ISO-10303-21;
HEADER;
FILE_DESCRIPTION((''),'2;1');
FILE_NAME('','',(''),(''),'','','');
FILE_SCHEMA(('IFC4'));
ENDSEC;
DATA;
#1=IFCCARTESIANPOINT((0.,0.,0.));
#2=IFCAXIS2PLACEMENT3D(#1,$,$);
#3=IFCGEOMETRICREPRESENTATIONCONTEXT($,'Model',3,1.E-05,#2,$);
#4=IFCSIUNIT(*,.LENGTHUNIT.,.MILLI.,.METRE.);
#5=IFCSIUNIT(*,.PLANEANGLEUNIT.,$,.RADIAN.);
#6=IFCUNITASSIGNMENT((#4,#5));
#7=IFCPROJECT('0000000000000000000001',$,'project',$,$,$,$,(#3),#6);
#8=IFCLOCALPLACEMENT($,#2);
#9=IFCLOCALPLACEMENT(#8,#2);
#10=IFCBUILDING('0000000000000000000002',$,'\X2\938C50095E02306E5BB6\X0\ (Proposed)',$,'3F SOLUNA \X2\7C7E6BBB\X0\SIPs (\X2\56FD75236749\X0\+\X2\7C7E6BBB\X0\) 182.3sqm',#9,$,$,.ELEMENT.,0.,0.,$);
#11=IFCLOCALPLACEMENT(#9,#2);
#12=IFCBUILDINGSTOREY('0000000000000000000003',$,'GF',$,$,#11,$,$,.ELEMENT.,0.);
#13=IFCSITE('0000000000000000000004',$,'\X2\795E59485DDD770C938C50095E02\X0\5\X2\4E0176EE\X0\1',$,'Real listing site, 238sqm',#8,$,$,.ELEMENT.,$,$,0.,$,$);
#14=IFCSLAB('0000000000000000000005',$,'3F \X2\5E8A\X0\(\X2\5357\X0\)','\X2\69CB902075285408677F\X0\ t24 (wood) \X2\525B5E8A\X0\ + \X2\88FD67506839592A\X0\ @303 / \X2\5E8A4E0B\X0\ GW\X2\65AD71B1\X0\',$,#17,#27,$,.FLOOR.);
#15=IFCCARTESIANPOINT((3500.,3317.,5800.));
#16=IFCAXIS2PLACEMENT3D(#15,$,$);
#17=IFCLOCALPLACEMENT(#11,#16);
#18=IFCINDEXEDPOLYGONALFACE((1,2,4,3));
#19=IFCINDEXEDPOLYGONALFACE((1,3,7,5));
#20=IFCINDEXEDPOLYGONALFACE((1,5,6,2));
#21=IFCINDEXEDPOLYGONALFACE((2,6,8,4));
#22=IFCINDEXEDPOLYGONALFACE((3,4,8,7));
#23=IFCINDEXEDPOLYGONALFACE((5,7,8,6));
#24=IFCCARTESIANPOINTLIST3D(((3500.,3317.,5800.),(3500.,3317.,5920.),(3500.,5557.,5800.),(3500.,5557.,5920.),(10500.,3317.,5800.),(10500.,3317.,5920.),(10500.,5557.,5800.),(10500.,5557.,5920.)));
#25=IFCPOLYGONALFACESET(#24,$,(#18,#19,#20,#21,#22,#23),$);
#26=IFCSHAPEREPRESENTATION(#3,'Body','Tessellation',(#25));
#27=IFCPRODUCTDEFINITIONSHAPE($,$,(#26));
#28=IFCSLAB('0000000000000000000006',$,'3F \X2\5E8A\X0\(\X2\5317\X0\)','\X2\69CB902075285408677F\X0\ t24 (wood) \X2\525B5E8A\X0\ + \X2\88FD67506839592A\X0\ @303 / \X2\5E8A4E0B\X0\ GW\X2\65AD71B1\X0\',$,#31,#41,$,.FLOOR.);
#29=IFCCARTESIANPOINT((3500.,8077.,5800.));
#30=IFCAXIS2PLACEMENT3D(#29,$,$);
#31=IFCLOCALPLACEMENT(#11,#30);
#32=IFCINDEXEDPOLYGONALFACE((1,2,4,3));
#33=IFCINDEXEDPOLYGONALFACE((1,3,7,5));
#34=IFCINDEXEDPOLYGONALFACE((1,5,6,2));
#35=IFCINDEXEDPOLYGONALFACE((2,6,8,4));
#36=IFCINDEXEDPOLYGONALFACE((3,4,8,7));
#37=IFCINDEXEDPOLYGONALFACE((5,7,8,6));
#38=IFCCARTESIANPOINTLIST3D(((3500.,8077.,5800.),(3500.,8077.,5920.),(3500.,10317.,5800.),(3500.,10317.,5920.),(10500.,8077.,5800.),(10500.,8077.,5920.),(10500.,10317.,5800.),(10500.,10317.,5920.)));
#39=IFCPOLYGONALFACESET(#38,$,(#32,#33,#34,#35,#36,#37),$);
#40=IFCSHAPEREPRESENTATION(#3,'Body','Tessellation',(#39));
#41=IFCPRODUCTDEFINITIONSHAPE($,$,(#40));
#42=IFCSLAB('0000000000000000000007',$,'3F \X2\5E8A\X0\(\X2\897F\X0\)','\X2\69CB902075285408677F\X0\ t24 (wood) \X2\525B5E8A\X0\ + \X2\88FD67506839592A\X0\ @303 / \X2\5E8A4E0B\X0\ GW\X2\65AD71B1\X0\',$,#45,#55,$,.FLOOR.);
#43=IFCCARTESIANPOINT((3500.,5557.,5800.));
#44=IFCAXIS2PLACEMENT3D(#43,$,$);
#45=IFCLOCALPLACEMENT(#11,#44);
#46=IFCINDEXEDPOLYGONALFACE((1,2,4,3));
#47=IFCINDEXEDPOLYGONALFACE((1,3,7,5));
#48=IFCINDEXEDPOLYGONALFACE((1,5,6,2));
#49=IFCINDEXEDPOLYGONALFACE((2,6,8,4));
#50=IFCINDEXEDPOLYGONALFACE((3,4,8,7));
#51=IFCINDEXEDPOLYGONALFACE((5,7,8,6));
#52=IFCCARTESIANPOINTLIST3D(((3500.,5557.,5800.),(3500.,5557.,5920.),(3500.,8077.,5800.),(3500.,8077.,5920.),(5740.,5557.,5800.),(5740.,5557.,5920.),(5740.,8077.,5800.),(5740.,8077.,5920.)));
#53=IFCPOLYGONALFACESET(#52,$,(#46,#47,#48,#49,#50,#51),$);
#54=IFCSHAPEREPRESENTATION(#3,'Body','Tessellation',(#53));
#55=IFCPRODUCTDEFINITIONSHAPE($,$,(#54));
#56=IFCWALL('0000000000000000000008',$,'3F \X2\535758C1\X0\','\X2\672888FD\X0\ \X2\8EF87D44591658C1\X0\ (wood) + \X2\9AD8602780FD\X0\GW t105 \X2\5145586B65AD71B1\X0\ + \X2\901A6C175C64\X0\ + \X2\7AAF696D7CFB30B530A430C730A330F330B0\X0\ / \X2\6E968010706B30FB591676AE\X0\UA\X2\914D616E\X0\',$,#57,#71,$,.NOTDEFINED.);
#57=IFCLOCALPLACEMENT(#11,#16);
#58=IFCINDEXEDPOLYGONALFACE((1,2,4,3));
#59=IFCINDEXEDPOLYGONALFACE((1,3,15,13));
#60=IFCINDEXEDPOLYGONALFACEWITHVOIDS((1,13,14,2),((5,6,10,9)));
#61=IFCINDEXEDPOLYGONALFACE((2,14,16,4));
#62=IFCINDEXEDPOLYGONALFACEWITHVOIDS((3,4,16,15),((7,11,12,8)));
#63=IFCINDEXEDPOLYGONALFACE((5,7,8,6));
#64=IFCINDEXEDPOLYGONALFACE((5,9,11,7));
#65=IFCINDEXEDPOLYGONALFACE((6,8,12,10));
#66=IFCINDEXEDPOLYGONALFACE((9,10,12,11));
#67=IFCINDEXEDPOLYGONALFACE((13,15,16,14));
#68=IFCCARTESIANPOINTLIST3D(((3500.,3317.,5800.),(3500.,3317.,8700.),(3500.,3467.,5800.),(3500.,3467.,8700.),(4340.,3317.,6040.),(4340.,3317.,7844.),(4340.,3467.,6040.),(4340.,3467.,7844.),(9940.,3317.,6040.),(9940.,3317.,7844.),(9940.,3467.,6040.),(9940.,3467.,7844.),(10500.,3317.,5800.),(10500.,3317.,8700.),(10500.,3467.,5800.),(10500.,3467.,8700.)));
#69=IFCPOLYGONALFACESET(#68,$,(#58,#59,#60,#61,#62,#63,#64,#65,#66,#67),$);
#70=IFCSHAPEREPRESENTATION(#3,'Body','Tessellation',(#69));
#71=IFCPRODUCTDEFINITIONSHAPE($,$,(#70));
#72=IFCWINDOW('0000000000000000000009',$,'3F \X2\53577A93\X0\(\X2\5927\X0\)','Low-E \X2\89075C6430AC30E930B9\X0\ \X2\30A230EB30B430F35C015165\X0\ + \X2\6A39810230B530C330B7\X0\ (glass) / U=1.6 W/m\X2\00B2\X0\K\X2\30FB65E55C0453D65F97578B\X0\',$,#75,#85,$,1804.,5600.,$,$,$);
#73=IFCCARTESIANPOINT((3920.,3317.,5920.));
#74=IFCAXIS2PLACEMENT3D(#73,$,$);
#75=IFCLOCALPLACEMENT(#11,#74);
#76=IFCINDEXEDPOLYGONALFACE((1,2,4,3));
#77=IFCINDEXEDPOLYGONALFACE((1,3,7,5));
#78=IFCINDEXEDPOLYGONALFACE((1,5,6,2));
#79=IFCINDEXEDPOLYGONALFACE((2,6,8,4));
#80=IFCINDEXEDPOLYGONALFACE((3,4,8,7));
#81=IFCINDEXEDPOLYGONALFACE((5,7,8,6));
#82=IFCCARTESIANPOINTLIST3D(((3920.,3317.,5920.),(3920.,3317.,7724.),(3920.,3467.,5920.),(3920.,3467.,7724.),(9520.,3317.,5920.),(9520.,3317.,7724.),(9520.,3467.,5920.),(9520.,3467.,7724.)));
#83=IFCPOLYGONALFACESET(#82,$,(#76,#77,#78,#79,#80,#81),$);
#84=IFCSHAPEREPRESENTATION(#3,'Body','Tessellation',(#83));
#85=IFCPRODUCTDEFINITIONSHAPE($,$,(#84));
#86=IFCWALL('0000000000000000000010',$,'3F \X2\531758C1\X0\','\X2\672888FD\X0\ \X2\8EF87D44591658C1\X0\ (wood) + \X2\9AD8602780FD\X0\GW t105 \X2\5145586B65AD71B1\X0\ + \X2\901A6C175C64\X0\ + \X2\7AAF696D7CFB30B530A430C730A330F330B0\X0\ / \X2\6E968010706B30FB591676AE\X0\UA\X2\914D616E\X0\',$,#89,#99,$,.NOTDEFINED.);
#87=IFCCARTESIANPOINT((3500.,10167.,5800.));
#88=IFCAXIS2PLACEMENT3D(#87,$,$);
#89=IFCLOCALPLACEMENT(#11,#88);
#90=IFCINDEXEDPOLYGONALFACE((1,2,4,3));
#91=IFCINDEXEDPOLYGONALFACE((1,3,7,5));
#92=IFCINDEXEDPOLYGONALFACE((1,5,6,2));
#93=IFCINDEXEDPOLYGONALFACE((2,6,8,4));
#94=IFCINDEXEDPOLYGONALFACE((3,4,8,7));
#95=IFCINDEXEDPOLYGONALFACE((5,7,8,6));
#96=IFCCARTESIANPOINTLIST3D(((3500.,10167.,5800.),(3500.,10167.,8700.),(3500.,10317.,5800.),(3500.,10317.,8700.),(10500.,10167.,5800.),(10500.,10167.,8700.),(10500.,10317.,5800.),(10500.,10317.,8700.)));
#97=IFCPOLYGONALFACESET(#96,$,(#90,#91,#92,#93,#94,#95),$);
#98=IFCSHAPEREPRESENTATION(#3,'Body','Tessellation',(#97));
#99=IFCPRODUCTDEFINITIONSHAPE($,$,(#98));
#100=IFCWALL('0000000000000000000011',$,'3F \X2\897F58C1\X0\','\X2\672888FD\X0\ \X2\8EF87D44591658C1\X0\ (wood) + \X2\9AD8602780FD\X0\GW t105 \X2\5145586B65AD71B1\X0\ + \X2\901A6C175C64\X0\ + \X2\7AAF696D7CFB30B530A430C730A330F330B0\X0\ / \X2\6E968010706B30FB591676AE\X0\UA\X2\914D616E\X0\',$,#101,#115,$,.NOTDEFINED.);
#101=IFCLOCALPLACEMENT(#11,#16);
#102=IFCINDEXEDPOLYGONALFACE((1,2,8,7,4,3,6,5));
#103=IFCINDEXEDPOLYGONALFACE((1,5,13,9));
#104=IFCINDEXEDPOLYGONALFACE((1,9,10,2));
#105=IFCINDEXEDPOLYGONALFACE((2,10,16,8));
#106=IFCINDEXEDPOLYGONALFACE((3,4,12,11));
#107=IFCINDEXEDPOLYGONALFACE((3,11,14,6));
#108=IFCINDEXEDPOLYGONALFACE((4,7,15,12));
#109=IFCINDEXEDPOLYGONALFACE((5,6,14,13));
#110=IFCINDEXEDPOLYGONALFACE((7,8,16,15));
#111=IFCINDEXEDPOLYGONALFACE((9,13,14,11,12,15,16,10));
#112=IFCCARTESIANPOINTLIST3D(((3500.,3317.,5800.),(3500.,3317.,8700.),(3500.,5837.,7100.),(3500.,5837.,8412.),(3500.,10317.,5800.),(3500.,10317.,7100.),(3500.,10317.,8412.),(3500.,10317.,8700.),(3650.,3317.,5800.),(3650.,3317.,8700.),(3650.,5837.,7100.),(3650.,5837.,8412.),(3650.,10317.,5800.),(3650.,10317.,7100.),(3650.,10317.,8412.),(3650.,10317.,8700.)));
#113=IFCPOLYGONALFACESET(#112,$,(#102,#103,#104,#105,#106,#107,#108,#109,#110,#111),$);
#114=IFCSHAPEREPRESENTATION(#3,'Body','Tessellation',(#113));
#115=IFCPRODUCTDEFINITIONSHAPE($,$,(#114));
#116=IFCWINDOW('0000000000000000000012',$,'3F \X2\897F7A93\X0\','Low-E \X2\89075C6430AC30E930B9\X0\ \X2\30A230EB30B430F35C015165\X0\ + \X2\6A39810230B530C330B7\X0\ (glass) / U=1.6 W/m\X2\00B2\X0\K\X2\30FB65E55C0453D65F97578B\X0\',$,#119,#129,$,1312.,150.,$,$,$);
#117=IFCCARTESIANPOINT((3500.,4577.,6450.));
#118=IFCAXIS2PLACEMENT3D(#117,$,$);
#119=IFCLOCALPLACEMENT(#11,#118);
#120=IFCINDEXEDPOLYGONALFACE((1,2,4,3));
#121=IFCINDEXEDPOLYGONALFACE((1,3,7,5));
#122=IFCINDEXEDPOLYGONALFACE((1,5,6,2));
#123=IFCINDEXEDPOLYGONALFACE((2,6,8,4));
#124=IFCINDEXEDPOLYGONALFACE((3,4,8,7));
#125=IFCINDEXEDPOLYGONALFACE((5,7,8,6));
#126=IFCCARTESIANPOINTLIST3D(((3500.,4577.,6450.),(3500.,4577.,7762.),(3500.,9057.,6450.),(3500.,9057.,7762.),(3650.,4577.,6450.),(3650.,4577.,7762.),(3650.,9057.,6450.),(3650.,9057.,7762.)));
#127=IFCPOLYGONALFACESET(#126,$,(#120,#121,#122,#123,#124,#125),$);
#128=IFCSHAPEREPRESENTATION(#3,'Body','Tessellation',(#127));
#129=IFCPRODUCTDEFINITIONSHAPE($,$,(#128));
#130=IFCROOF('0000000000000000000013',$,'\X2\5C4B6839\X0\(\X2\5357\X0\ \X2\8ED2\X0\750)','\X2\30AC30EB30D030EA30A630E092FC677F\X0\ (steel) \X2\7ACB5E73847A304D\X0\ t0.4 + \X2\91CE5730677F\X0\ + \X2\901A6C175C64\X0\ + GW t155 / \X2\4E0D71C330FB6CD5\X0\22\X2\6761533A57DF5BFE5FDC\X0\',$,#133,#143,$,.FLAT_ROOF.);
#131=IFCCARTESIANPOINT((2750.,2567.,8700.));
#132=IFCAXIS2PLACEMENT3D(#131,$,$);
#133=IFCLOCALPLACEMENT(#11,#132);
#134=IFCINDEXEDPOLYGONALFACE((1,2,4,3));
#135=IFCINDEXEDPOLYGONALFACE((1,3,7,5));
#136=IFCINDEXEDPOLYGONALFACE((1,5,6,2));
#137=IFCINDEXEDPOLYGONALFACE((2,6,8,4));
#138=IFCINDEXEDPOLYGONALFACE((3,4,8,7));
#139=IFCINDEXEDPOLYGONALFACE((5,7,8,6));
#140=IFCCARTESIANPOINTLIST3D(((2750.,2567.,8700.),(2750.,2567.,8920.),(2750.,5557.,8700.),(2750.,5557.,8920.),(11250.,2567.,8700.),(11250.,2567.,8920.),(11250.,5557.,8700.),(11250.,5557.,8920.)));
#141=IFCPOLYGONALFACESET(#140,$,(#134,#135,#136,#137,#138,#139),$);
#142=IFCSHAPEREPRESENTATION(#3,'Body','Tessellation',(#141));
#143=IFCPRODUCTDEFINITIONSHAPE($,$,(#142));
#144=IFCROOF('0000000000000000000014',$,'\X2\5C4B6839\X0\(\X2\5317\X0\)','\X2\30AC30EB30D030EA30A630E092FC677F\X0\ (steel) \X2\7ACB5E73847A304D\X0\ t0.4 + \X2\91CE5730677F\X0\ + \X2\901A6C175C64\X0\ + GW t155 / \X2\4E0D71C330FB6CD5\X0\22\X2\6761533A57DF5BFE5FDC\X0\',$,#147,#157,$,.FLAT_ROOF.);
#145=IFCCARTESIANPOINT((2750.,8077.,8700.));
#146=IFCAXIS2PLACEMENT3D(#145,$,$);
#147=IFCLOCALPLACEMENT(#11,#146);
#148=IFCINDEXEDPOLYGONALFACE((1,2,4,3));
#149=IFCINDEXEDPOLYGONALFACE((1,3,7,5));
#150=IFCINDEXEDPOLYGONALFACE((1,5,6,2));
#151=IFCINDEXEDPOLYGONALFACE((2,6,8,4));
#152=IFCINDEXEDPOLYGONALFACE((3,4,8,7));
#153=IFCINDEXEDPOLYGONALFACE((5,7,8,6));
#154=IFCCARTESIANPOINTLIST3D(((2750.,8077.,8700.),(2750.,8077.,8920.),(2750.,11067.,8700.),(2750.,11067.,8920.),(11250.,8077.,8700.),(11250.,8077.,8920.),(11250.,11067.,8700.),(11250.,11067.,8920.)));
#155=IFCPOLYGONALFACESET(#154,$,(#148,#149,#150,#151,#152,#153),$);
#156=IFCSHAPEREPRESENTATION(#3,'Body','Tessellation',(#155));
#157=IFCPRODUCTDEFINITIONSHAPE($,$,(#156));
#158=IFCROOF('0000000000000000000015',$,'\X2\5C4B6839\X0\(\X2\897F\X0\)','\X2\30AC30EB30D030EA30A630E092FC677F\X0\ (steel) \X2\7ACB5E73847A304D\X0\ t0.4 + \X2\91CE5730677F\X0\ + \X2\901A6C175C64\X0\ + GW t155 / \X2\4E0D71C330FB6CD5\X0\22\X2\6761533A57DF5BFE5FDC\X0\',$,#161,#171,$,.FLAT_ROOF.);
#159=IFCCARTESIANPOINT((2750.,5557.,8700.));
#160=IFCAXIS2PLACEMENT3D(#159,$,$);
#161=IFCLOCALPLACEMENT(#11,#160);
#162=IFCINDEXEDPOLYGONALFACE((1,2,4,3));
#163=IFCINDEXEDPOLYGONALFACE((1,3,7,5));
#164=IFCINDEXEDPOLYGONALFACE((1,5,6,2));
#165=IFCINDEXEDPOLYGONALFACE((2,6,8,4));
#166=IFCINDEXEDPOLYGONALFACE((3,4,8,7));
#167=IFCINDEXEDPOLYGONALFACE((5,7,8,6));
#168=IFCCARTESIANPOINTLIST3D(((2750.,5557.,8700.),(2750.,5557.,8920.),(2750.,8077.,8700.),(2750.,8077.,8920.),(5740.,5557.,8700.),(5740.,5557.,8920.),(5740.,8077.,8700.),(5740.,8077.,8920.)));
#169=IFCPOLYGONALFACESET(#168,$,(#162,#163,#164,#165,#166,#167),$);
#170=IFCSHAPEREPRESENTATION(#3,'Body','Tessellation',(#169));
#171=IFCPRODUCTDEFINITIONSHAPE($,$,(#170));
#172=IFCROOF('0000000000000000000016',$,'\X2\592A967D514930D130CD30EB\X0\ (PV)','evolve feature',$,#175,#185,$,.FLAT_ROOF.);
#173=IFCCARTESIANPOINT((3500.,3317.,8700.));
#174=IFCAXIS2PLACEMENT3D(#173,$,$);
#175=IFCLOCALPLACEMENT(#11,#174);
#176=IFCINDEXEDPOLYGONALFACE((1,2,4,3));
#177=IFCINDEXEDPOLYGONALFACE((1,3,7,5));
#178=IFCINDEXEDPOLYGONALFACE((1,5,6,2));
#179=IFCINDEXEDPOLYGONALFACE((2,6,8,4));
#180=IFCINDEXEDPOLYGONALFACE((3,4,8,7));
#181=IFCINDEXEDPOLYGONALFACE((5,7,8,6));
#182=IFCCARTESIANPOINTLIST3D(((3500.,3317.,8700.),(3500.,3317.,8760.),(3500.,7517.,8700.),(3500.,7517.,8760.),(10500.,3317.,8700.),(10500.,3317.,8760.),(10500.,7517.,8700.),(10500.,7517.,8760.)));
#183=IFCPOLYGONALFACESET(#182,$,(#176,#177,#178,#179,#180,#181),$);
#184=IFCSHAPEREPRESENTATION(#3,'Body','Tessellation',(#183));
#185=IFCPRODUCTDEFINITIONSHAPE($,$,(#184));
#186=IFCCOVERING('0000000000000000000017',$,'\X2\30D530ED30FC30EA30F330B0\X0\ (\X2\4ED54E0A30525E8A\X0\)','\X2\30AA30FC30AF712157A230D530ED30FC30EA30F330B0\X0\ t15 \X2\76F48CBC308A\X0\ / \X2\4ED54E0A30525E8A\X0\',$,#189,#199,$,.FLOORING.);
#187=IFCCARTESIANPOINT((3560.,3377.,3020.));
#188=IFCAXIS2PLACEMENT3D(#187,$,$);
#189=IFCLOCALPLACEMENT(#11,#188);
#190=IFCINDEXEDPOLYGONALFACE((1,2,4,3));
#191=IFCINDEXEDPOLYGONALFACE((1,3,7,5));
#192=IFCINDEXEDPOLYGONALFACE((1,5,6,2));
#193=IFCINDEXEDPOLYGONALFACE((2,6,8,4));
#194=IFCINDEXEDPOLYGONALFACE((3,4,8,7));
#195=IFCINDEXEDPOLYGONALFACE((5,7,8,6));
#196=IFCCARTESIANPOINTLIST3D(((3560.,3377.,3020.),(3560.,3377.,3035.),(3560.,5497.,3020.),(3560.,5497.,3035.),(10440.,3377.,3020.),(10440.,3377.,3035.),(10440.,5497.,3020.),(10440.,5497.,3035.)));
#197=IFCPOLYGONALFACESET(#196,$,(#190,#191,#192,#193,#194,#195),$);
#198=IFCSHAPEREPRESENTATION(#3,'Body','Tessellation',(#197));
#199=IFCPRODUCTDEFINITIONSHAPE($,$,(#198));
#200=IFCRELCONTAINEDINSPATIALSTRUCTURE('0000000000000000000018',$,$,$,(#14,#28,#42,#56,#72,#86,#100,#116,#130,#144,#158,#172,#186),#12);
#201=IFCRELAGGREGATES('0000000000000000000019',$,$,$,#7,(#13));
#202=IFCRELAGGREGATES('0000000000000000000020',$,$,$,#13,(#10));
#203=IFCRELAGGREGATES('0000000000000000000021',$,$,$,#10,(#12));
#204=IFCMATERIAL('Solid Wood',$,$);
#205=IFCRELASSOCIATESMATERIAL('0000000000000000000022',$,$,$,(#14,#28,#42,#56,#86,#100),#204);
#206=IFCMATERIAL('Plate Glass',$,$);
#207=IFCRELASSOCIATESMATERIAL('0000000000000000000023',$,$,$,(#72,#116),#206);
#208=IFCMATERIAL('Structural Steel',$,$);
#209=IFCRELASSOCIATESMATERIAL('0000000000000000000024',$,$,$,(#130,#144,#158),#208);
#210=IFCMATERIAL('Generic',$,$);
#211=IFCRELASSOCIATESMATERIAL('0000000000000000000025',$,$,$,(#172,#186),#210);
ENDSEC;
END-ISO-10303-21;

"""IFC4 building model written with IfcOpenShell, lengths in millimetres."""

from ifc_helpers import new_model, si_unit, frame, frame_2d, origin, place, context, project, spatial, rectangle, extrude, material, element, fill, save


model = new_model("IFC4")

# Units and contexts
model_context = context("Model", 3, precision=1e-05, world=origin())
ifc_project = project(units=[si_unit("LENGTHUNIT", "METRE", prefix="MILLI"), si_unit("PLANEANGLEUNIT", "RADIAN")], contexts=[model_context])

# Site, building, storey
site_placement = place(None, origin())
site = spatial("IfcSite", under=ifc_project, at=site_placement, Name="神奈川県鎌倉市5丁目1", ObjectType="Real listing site, 238sqm", CompositionType="ELEMENT", RefElevation=0.0)
building_placement = place(site_placement, origin())
building = spatial("IfcBuilding", under=site, at=building_placement, Name="鎌倉市の家 (Proposed)", ObjectType="3F SOLUNA 籾殻SIPs (国産杉+籾殻) 182.3sqm", CompositionType="ELEMENT", ElevationOfRefHeight=0.0, ElevationOfTerrain=0.0)
storey_placement = place(building_placement, origin())
storey = spatial("IfcBuildingStorey", under=building, at=storey_placement, Name="GF", CompositionType="ELEMENT", Elevation=0.0)

# Slabs
ifc_material_1 = material(Name="Solid Wood")
slab_1_placement = place(storey_placement, frame((3500.0, 3317.0, 5800.0)))
element("IfcSlab", 1, at=slab_1_placement, inside=storey, material=ifc_material_1, Name="3F 床(南)", Description="構造用合板 t24 (wood) 剛床 + 製材根太 @303 / 床下 GW断熱", PredefinedType="FLOOR", context=model_context, shape_type="SweptSolid", body=[
    extrude(rectangle(XDim=7000.0, YDim=2240.0, at=frame_2d((3500.0, 1120.0))), frame((3500.0, 3317.0, 5800.0)), (0.0, 0.0, 1.0), 120.0),
])
slab_2_placement = place(storey_placement, frame((3500.0, 8077.0, 5800.0)))
element("IfcSlab", 2, at=slab_2_placement, inside=storey, material=ifc_material_1, Name="3F 床(北)", Description="構造用合板 t24 (wood) 剛床 + 製材根太 @303 / 床下 GW断熱", PredefinedType="FLOOR", context=model_context, shape_type="SweptSolid", body=[
    extrude(rectangle(XDim=7000.0, YDim=2240.0, at=frame_2d((3500.0, 1120.0))), frame((3500.0, 8077.0, 5800.0)), (0.0, 0.0, 1.0), 120.0),
])
slab_3_placement = place(storey_placement, frame((3500.0, 5557.0, 5800.0)))
element("IfcSlab", 3, at=slab_3_placement, inside=storey, material=ifc_material_1, Name="3F 床(西)", Description="構造用合板 t24 (wood) 剛床 + 製材根太 @303 / 床下 GW断熱", PredefinedType="FLOOR", context=model_context, shape_type="SweptSolid", body=[
    extrude(rectangle(XDim=2240.0, YDim=2520.0, at=frame_2d((1120.0, 1260.0))), frame((3500.0, 5557.0, 5800.0)), (0.0, 0.0, 1.0), 120.0),
])

# Wall, opening, window
wall_1_placement = place(storey_placement, frame((3500.0, 3317.0, 5800.0)))
wall_1 = element("IfcWall", 4, at=wall_1_placement, inside=storey, material=ifc_material_1, Name="3F 南壁", Description="木製 軸組外壁 (wood) + 高性能GW t105 充填断熱 + 通気層 + 窯業系サイディング / 準耐火・外皮UA配慮", PredefinedType="NOTDEFINED", context=model_context, shape_type="SweptSolid", body=[
    extrude(rectangle(XDim=7000.0, YDim=150.0, at=frame_2d((3500.0, 75.0))), frame((3500.0, 3317.0, 5800.0)), (0.0, 0.0, 1.0), 2900.0),
])
opening_1_placement = place(storey_placement, frame((3920.0, 3317.0, 5920.0)))
opening_1 = element("IfcOpeningElement", 5, at=opening_1_placement, cuts=wall_1, PredefinedType="NOTDEFINED", context=model_context, shape_type="SweptSolid", body=[
    extrude(rectangle(XDim=5600.0, YDim=150.0, at=frame_2d((2800.0, 75.0))), frame((3920.0, 3317.0, 5920.0)), (0.0, 0.0, 1.0), 1804.0),
])
ifc_material_2 = material(Name="Plate Glass")
window_1_placement = place(storey_placement, frame((3920.0, 3317.0, 5920.0)))
window_1 = element("IfcWindow", 6, at=window_1_placement, inside=storey, material=ifc_material_2, Name="3F 南窓(大)", Description="Low-E 複層ガラス アルゴン封入 + 樹脂サッシ (glass) / U=1.6 W/m²K・日射取得型", OverallHeight=1804.0, OverallWidth=5600.0, context=model_context, shape_type="SweptSolid", body=[
    extrude(rectangle(XDim=5600.0, YDim=150.0, at=frame_2d((2800.0, 75.0))), frame((3920.0, 3317.0, 5920.0)), (0.0, 0.0, 1.0), 1804.0),
])
fill(opening_1, window_1)

# Wall
wall_2_placement = place(storey_placement, frame((3500.0, 10167.0, 5800.0)))
element("IfcWall", 7, at=wall_2_placement, inside=storey, material=ifc_material_1, Name="3F 北壁", Description="木製 軸組外壁 (wood) + 高性能GW t105 充填断熱 + 通気層 + 窯業系サイディング / 準耐火・外皮UA配慮", PredefinedType="NOTDEFINED", context=model_context, shape_type="SweptSolid", body=[
    extrude(rectangle(XDim=7000.0, YDim=150.0, at=frame_2d((3500.0, 75.0))), frame((3500.0, 10167.0, 5800.0)), (0.0, 0.0, 1.0), 2900.0),
])

# Wall, opening, window
wall_3_placement = place(storey_placement, frame((3500.0, 3317.0, 5800.0)))
wall_3 = element("IfcWall", 8, at=wall_3_placement, inside=storey, material=ifc_material_1, Name="3F 西壁", Description="木製 軸組外壁 (wood) + 高性能GW t105 充填断熱 + 通気層 + 窯業系サイディング / 準耐火・外皮UA配慮", PredefinedType="NOTDEFINED", context=model_context, shape_type="SweptSolid", body=[
    extrude(rectangle(XDim=150.0, YDim=7000.0, at=frame_2d((75.0, 3500.0))), frame((3500.0, 3317.0, 5800.0)), (0.0, 0.0, 1.0), 2900.0),
])
opening_2_placement = place(storey_placement, frame((3500.0, 4577.0, 6450.0)))
opening_2 = element("IfcOpeningElement", 9, at=opening_2_placement, cuts=wall_3, PredefinedType="NOTDEFINED", context=model_context, shape_type="SweptSolid", body=[
    extrude(rectangle(XDim=150.0, YDim=4480.0, at=frame_2d((75.0, 2240.0))), frame((3500.0, 4577.0, 6450.0)), (0.0, 0.0, 1.0), 1312.0),
])
window_2_placement = place(storey_placement, frame((3500.0, 4577.0, 6450.0)))
window_2 = element("IfcWindow", 10, at=window_2_placement, inside=storey, material=ifc_material_2, Name="3F 西窓", Description="Low-E 複層ガラス アルゴン封入 + 樹脂サッシ (glass) / U=1.6 W/m²K・日射取得型", OverallHeight=1312.0, OverallWidth=150.0, context=model_context, shape_type="SweptSolid", body=[
    extrude(rectangle(XDim=150.0, YDim=4480.0, at=frame_2d((75.0, 2240.0))), frame((3500.0, 4577.0, 6450.0)), (0.0, 0.0, 1.0), 1312.0),
])
fill(opening_2, window_2)

# Roofs
ifc_material_3 = material(Name="Structural Steel")
roof_1_placement = place(storey_placement, frame((2750.0, 2567.0, 8700.0)))
element("IfcRoof", 11, at=roof_1_placement, inside=storey, material=ifc_material_3, Name="屋根(南 軒750)", Description="ガルバリウム鋼板 (steel) 立平葺き t0.4 + 野地板 + 通気層 + GW t155 / 不燃・法22条区域対応", PredefinedType="FLAT_ROOF", context=model_context, shape_type="SweptSolid", body=[
    extrude(rectangle(XDim=8500.0, YDim=2990.0, at=frame_2d((4250.0, 1495.0))), frame((2750.0, 2567.0, 8700.0)), (0.0, 0.0, 1.0), 220.0),
])
roof_2_placement = place(storey_placement, frame((2750.0, 8077.0, 8700.0)))
element("IfcRoof", 12, at=roof_2_placement, inside=storey, material=ifc_material_3, Name="屋根(北)", Description="ガルバリウム鋼板 (steel) 立平葺き t0.4 + 野地板 + 通気層 + GW t155 / 不燃・法22条区域対応", PredefinedType="FLAT_ROOF", context=model_context, shape_type="SweptSolid", body=[
    extrude(rectangle(XDim=8500.0, YDim=2990.0, at=frame_2d((4250.0, 1495.0))), frame((2750.0, 8077.0, 8700.0)), (0.0, 0.0, 1.0), 220.0),
])
roof_3_placement = place(storey_placement, frame((2750.0, 5557.0, 8700.0)))
element("IfcRoof", 13, at=roof_3_placement, inside=storey, material=ifc_material_3, Name="屋根(西)", Description="ガルバリウム鋼板 (steel) 立平葺き t0.4 + 野地板 + 通気層 + GW t155 / 不燃・法22条区域対応", PredefinedType="FLAT_ROOF", context=model_context, shape_type="SweptSolid", body=[
    extrude(rectangle(XDim=2990.0, YDim=2520.0, at=frame_2d((1495.0, 1260.0))), frame((2750.0, 5557.0, 8700.0)), (0.0, 0.0, 1.0), 220.0),
])
ifc_material_4 = material(Name="Generic")
roof_4_placement = place(storey_placement, frame((3500.0, 3317.0, 8700.0)))
element("IfcRoof", 14, at=roof_4_placement, inside=storey, material=ifc_material_4, Name="太陽光パネル (PV)", Description="evolve feature", PredefinedType="FLAT_ROOF", context=model_context, shape_type="SweptSolid", body=[
    extrude(rectangle(XDim=7000.0, YDim=4200.0, at=frame_2d((3500.0, 2100.0))), frame((3500.0, 3317.0, 8700.0)), (0.0, 0.0, 1.0), 60.0),
])

# Covering
covering_1_placement = place(storey_placement, frame((3560.0, 3377.0, 3020.0)))
element("IfcCovering", 15, at=covering_1_placement, inside=storey, material=ifc_material_4, Name="フローリング (仕上げ床)", Description="オーク無垢フローリング t15 直貼り / 仕上げ床", PredefinedType="FLOORING", context=model_context, shape_type="SweptSolid", body=[
    extrude(rectangle(XDim=6880.0, YDim=2120.0, at=frame_2d((3440.0, 1060.0))), frame((3560.0, 3377.0, 3020.0)), (0.0, 0.0, 1.0), 15.0),
])

save(model, "model.ifc")
